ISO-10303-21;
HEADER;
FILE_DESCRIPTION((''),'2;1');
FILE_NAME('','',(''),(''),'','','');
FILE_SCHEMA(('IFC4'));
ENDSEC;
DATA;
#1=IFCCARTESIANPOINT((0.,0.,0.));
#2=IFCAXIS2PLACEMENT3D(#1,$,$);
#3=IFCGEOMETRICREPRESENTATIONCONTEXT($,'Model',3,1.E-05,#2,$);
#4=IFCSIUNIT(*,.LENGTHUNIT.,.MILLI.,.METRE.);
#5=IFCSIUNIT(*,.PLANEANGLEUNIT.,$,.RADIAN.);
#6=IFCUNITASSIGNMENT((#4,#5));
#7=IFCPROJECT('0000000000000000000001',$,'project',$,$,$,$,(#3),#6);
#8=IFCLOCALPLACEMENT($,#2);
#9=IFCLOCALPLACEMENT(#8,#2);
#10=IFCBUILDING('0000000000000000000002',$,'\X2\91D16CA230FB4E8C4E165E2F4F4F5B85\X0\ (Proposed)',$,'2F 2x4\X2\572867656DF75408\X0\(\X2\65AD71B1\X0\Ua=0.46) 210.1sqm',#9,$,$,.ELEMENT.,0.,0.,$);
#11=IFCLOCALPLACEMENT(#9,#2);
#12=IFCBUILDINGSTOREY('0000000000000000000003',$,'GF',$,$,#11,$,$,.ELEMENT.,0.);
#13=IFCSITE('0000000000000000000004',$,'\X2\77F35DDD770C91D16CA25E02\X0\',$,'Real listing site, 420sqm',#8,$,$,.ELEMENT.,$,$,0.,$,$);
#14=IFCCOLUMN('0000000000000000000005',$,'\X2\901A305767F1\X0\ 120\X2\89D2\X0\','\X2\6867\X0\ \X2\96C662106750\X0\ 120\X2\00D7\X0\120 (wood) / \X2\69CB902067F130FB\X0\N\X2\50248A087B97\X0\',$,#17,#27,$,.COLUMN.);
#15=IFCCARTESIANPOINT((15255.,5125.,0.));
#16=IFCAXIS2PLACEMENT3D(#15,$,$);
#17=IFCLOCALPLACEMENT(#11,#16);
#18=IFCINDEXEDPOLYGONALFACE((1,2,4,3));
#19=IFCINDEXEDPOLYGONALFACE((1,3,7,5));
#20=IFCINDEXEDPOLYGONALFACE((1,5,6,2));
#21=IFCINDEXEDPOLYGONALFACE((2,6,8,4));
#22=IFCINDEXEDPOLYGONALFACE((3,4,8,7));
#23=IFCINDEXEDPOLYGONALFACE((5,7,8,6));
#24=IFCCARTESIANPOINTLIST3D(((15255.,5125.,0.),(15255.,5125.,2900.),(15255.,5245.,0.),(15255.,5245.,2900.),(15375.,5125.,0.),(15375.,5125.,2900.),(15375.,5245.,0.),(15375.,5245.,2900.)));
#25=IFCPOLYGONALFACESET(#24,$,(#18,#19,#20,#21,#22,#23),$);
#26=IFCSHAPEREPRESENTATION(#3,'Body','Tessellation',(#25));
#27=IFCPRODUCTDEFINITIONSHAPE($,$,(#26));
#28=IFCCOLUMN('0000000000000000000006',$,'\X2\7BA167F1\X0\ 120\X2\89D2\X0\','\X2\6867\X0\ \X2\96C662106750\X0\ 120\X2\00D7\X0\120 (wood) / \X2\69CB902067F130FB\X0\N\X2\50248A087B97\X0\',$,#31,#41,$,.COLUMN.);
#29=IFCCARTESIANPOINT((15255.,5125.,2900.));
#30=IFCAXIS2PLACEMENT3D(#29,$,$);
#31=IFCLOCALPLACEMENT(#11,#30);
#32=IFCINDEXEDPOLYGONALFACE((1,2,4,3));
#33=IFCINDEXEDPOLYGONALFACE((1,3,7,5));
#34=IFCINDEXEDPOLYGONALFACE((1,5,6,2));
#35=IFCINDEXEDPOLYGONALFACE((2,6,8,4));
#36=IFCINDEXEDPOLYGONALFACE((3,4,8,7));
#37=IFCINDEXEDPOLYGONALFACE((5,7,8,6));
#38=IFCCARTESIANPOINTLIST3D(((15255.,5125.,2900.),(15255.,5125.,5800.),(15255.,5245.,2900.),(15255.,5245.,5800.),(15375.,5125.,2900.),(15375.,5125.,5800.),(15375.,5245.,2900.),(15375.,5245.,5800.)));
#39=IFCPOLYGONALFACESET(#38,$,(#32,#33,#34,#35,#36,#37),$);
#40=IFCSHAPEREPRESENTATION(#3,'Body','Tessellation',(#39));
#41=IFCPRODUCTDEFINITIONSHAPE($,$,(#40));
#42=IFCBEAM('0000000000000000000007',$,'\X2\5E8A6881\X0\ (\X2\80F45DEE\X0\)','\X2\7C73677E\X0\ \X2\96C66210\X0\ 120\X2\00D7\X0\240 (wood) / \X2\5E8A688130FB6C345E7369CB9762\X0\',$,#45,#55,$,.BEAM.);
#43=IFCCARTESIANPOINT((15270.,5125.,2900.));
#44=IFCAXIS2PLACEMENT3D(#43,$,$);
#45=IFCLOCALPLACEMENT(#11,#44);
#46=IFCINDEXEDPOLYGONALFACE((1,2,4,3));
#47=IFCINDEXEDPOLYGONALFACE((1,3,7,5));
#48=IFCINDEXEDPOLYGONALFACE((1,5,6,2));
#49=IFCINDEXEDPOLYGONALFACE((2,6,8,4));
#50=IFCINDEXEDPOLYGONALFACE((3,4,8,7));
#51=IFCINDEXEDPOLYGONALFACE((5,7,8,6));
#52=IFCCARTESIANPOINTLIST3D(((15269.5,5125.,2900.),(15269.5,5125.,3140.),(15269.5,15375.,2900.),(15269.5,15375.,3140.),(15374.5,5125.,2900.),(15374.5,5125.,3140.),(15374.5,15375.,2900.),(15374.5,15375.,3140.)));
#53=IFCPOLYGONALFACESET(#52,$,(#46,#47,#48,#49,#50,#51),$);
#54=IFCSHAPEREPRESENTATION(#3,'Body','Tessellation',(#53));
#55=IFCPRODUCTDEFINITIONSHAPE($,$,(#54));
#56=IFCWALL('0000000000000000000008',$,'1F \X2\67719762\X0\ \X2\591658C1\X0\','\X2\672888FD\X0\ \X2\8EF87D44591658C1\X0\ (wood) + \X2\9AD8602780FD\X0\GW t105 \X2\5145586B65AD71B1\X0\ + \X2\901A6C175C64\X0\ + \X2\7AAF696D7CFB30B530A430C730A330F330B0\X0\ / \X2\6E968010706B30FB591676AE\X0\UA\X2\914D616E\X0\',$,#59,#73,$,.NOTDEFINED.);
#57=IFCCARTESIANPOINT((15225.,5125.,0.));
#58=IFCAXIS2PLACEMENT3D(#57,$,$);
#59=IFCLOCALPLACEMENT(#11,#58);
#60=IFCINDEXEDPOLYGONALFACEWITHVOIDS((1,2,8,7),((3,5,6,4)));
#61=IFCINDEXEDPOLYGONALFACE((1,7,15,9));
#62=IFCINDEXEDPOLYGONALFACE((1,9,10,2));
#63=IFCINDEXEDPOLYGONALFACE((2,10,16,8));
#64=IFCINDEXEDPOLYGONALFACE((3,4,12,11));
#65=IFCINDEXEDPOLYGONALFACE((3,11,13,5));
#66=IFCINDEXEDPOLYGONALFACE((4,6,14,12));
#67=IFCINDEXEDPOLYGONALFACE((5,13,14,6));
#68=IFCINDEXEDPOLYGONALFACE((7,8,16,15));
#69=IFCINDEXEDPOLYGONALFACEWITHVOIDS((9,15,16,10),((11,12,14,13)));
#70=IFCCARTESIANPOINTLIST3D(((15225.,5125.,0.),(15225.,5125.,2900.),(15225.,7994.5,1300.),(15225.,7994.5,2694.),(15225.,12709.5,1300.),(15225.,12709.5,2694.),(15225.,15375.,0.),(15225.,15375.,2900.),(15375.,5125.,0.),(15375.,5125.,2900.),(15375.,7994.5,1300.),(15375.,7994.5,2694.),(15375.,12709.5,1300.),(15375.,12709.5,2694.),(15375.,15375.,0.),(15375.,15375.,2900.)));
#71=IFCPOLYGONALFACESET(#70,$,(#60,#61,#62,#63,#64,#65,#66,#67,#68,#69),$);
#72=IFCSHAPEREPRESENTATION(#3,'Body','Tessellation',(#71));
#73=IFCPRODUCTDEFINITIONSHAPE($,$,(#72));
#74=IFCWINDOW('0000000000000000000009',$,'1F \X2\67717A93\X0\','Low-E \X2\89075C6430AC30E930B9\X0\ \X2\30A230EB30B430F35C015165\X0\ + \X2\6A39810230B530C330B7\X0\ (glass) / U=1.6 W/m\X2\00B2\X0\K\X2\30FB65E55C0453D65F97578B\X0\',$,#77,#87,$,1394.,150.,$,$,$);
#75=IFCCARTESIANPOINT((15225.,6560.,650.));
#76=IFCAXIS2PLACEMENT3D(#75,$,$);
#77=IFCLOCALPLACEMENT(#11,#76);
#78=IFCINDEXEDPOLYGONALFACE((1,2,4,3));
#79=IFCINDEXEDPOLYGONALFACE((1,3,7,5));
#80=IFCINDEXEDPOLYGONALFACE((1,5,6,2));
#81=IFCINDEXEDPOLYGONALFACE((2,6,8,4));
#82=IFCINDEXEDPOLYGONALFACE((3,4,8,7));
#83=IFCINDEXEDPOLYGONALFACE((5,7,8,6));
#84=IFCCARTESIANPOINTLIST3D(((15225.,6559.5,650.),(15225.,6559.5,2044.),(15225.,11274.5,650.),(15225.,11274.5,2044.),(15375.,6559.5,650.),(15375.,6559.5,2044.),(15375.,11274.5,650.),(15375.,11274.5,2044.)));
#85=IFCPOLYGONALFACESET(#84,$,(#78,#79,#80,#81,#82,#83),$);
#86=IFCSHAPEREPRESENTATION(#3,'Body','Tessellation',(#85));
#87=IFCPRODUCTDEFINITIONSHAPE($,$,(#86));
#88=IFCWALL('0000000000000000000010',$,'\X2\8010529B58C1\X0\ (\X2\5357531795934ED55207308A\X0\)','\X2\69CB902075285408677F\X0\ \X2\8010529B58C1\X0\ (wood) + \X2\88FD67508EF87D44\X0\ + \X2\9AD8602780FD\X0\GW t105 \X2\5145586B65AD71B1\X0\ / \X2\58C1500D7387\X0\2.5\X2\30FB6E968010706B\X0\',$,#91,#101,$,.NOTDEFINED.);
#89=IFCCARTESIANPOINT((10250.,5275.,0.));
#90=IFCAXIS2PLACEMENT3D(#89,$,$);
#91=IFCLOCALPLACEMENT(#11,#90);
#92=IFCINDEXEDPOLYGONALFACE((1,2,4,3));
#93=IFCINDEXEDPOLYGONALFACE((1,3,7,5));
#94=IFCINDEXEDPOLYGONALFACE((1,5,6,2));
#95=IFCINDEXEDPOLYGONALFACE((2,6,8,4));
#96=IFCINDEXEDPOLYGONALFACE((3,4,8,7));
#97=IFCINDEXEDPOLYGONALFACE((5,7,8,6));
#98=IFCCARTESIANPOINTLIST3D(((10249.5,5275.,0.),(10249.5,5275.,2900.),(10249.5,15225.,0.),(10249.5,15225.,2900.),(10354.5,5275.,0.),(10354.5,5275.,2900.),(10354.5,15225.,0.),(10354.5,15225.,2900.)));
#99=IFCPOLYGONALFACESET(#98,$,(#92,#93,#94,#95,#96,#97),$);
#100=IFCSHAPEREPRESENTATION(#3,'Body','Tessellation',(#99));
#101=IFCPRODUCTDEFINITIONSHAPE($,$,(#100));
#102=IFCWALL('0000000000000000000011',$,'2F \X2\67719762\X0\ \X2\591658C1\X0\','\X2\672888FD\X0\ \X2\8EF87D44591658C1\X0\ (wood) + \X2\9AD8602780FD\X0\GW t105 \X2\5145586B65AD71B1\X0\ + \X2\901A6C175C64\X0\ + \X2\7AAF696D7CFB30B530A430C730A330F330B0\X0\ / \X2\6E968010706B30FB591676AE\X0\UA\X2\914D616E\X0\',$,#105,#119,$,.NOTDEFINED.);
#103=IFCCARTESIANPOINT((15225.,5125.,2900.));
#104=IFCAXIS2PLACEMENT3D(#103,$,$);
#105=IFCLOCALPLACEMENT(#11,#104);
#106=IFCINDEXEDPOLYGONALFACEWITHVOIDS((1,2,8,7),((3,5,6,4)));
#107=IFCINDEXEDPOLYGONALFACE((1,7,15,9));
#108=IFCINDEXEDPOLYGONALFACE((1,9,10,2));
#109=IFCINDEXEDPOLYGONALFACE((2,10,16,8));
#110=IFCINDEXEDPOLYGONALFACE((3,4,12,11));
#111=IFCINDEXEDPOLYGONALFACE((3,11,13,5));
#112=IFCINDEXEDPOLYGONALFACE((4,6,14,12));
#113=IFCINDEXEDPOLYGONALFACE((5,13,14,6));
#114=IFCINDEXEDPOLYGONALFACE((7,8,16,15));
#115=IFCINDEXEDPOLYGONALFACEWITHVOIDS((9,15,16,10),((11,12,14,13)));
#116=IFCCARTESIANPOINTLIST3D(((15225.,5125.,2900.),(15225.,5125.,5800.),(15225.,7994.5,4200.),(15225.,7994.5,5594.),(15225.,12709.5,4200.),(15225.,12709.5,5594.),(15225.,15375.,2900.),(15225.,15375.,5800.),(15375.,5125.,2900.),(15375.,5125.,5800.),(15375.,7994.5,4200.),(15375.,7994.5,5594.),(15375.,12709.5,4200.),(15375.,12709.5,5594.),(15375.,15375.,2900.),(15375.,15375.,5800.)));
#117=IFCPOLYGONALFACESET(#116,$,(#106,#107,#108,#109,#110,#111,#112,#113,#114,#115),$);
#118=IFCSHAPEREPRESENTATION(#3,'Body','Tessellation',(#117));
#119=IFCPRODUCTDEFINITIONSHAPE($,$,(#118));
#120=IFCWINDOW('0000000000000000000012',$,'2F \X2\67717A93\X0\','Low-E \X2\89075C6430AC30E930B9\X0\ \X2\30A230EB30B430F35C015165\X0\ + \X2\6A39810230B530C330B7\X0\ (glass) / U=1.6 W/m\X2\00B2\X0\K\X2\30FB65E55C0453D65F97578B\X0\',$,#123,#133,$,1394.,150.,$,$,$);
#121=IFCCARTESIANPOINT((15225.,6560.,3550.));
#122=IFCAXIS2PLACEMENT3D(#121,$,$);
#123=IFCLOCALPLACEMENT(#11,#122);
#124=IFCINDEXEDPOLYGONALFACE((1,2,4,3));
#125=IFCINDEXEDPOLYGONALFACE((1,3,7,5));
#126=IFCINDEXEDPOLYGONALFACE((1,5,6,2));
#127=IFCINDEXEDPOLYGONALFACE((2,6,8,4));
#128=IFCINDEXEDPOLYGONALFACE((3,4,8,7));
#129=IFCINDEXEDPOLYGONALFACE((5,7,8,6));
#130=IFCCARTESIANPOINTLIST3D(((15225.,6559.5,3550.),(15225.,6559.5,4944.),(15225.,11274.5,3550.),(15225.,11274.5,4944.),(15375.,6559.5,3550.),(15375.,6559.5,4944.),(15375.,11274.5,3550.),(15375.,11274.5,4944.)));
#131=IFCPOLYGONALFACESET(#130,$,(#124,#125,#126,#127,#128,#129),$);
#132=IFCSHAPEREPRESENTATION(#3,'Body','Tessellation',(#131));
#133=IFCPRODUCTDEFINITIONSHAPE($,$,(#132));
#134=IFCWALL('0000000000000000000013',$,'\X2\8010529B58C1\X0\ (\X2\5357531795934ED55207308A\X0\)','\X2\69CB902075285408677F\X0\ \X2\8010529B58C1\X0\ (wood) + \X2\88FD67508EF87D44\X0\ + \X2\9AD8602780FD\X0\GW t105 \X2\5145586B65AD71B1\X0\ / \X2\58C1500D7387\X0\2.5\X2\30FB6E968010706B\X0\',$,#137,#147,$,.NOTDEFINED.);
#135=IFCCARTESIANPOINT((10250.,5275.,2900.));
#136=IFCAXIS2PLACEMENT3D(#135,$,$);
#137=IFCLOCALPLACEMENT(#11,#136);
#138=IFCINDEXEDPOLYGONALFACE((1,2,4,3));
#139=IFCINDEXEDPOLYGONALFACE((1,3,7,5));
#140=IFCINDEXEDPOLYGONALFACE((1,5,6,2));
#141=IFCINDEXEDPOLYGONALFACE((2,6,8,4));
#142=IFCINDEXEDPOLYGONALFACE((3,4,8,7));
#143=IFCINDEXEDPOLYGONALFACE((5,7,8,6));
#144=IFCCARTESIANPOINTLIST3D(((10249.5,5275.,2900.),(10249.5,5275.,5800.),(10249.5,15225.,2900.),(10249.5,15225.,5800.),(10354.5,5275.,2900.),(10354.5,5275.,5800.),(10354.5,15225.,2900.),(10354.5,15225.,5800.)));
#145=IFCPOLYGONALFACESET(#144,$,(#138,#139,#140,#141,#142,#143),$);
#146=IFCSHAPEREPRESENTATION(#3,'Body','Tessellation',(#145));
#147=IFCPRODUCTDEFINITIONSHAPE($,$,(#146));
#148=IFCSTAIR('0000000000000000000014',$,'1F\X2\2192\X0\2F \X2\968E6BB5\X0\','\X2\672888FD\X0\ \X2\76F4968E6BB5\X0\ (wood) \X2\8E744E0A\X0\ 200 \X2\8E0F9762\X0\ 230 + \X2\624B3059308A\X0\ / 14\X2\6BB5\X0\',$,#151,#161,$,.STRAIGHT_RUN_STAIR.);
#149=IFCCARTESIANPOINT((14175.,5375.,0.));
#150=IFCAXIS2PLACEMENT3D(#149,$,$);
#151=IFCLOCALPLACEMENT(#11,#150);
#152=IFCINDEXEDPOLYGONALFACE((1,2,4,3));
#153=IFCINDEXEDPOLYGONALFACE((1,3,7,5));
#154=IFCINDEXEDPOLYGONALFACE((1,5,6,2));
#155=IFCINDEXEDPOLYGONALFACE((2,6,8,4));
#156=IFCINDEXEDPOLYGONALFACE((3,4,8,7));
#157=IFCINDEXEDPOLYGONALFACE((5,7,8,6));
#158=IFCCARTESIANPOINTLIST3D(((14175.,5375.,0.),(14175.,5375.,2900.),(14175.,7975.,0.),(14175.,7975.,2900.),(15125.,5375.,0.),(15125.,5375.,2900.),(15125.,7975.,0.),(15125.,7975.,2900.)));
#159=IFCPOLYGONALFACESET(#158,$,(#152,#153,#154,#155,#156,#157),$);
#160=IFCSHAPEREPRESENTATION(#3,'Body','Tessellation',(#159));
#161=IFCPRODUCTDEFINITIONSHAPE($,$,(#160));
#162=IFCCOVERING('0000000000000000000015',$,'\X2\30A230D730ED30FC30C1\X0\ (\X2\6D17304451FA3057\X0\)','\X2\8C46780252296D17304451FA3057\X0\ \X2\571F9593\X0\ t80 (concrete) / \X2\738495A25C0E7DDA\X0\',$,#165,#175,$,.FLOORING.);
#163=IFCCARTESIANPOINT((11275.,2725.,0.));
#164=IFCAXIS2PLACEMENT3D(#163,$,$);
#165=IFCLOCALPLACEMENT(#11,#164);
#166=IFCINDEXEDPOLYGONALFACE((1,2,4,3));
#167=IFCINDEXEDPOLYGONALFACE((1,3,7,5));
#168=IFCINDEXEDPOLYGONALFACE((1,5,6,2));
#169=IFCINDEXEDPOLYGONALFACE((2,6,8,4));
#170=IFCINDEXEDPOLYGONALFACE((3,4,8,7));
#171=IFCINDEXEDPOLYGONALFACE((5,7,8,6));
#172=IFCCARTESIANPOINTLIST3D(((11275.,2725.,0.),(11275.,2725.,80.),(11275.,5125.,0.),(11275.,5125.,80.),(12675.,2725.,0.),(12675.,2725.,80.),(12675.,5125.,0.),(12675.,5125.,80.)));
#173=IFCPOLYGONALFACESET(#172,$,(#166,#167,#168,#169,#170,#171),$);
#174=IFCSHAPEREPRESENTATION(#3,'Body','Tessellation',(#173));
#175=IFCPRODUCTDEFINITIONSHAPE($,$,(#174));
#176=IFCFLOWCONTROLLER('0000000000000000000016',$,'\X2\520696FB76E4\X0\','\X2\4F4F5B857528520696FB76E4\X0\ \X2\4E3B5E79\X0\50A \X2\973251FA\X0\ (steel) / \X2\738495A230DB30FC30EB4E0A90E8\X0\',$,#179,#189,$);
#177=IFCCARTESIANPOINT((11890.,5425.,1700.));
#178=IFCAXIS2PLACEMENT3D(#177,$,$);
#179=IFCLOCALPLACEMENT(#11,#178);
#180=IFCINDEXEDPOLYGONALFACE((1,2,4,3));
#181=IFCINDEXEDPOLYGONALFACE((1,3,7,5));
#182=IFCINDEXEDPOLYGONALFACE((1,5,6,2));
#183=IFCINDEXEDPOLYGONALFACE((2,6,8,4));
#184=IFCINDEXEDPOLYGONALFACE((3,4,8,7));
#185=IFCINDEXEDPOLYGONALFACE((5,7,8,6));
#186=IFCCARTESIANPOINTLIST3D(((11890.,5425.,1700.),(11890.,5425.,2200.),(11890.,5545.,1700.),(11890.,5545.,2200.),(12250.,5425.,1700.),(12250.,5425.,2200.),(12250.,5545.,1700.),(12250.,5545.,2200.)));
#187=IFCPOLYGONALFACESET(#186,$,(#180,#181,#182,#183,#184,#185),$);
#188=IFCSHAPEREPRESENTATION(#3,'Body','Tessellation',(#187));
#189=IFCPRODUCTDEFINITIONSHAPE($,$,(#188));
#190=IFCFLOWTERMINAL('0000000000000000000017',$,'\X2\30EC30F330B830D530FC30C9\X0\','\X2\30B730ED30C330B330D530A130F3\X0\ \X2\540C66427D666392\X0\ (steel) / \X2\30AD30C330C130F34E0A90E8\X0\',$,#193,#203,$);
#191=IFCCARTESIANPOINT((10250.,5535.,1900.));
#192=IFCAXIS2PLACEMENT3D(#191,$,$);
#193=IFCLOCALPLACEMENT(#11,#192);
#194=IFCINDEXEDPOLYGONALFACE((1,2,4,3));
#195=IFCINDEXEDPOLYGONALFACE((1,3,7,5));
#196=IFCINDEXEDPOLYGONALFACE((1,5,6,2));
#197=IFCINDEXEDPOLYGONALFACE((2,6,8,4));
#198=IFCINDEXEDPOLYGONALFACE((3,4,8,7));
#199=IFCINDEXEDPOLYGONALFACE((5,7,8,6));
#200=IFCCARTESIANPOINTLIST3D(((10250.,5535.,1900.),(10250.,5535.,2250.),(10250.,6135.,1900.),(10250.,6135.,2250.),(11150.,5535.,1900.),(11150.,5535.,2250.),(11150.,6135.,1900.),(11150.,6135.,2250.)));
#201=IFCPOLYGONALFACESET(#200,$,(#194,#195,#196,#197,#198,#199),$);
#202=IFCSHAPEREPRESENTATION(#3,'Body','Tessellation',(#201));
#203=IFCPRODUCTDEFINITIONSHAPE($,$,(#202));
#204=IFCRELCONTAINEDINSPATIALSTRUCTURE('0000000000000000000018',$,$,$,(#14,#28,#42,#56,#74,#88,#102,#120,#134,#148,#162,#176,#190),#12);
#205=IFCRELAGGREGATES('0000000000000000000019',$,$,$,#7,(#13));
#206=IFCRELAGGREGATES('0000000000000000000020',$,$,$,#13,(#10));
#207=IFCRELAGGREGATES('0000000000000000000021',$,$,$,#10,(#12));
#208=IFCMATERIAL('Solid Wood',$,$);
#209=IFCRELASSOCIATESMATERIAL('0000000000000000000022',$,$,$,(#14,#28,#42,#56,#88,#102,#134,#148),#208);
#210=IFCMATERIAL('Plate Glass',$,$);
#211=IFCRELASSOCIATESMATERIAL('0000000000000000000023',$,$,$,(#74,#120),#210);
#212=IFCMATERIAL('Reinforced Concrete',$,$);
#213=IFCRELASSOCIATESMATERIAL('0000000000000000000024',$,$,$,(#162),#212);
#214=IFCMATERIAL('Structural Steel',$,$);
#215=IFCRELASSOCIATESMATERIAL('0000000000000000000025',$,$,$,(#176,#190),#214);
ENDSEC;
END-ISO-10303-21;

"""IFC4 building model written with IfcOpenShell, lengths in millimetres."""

from ifc_helpers import new_model, si_unit, frame, frame_2d, origin, place, context, project, spatial, rectangle, extrude, material, element, fill, save


model = new_model("IFC4")

# Units and contexts
model_context = context("Model", 3, precision=1e-05, world=origin())
ifc_project = project(units=[si_unit("LENGTHUNIT", "METRE", prefix="MILLI"), si_unit("PLANEANGLEUNIT", "RADIAN")], contexts=[model_context])

# Site, building, storey
site_placement = place(None, origin())
site = spatial("IfcSite", under=ifc_project, at=site_placement, Name="石川県金沢市", ObjectType="Real listing site, 420sqm", CompositionType="ELEMENT", RefElevation=0.0)
building_placement = place(site_placement, origin())
building = spatial("IfcBuilding", under=site, at=building_placement, Name="金沢・二世帯住宅 (Proposed)", ObjectType="2F 2x4在来混合(断熱Ua=0.46) 210.1sqm", CompositionType="ELEMENT", ElevationOfRefHeight=0.0, ElevationOfTerrain=0.0)
storey_placement = place(building_placement, origin())
storey = spatial("IfcBuildingStorey", under=building, at=storey_placement, Name="GF", CompositionType="ELEMENT", Elevation=0.0)

# Columns
ifc_material_1 = material(Name="Solid Wood")
column_1_placement = place(storey_placement, frame((15255.0, 5125.0, 0.0)))
element("IfcColumn", 1, at=column_1_placement, inside=storey, material=ifc_material_1, Name="通し柱 120角", Description="桧 集成材 120×120 (wood) / 構造柱・N値計算", PredefinedType="COLUMN", context=model_context, shape_type="SweptSolid", body=[
    extrude(rectangle(XDim=120.0, YDim=120.0, at=frame_2d((60.0, 60.0))), frame((15255.0, 5125.0, 0.0)), (0.0, 0.0, 1.0), 2900.0),
])
column_2_placement = place(storey_placement, frame((15255.0, 5125.0, 2900.0)))
element("IfcColumn", 2, at=column_2_placement, inside=storey, material=ifc_material_1, Name="管柱 120角", Description="桧 集成材 120×120 (wood) / 構造柱・N値計算", PredefinedType="COLUMN", context=model_context, shape_type="SweptSolid", body=[
    extrude(rectangle(XDim=120.0, YDim=120.0, at=frame_2d((60.0, 60.0))), frame((15255.0, 5125.0, 2900.0)), (0.0, 0.0, 1.0), 2900.0),
])

# Beam
beam_1_placement = place(storey_placement, frame((15270.0, 5125.0, 2900.0)))
element("IfcBeam", 3, at=beam_1_placement, inside=storey, material=ifc_material_1, Name="床梁 (胴差)", Description="米松 集成 120×240 (wood) / 床梁・水平構面", PredefinedType="BEAM", context=model_context, shape_type="SweptSolid", body=[
    extrude(rectangle(XDim=105.0, YDim=10250.0, at=frame_2d((52.0, 5125.0))), frame((15270.0, 5125.0, 2900.0)), (0.0, 0.0, 1.0), 240.0),
])

# Wall, opening, window
wall_1_placement = place(storey_placement, frame((15225.0, 5125.0, 0.0)))
wall_1 = element("IfcWall", 4, at=wall_1_placement, inside=storey, material=ifc_material_1, Name="1F 東面 外壁", Description="木製 軸組外壁 (wood) + 高性能GW t105 充填断熱 + 通気層 + 窯業系サイディング / 準耐火・外皮UA配慮", PredefinedType="NOTDEFINED", context=model_context, shape_type="SweptSolid", body=[
    extrude(rectangle(XDim=150.0, YDim=10250.0, at=frame_2d((75.0, 5125.0))), frame((15225.0, 5125.0, 0.0)), (0.0, 0.0, 1.0), 2900.0),
])
opening_1_placement = place(storey_placement, frame((15225.0, 6560.0, 650.0)))
opening_1 = element("IfcOpeningElement", 5, at=opening_1_placement, cuts=wall_1, PredefinedType="NOTDEFINED", context=model_context, shape_type="SweptSolid", body=[
    extrude(rectangle(XDim=150.0, YDim=4715.0, at=frame_2d((75.0, 2357.0))), frame((15225.0, 6560.0, 650.0)), (0.0, 0.0, 1.0), 1394.0),
])
ifc_material_2 = material(Name="Plate Glass")
window_1_placement = place(storey_placement, frame((15225.0, 6560.0, 650.0)))
window_1 = element("IfcWindow", 6, at=window_1_placement, inside=storey, material=ifc_material_2, Name="1F 東窓", Description="Low-E 複層ガラス アルゴン封入 + 樹脂サッシ (glass) / U=1.6 W/m²K・日射取得型", OverallHeight=1394.0, OverallWidth=150.0, context=model_context, shape_type="SweptSolid", body=[
    extrude(rectangle(XDim=150.0, YDim=4715.0, at=frame_2d((75.0, 2357.0))), frame((15225.0, 6560.0, 650.0)), (0.0, 0.0, 1.0), 1394.0),
])
fill(opening_1, window_1)

# Wall
wall_2_placement = place(storey_placement, frame((10250.0, 5275.0, 0.0)))
element("IfcWall", 7, at=wall_2_placement, inside=storey, material=ifc_material_1, Name="耐力壁 (南北間仕切り)", Description="構造用合板 耐力壁 (wood) + 製材軸組 + 高性能GW t105 充填断熱 / 壁倍率2.5・準耐火", PredefinedType="NOTDEFINED", context=model_context, shape_type="SweptSolid", body=[
    extrude(rectangle(XDim=105.0, YDim=9950.0, at=frame_2d((52.0, 4975.0))), frame((10250.0, 5275.0, 0.0)), (0.0, 0.0, 1.0), 2900.0),
])

# Wall, opening, window
wall_3_placement = place(storey_placement, frame((15225.0, 5125.0, 2900.0)))
wall_3 = element("IfcWall", 8, at=wall_3_placement, inside=storey, material=ifc_material_1, Name="2F 東面 外壁", Description="木製 軸組外壁 (wood) + 高性能GW t105 充填断熱 + 通気層 + 窯業系サイディング / 準耐火・外皮UA配慮", PredefinedType="NOTDEFINED", context=model_context, shape_type="SweptSolid", body=[
    extrude(rectangle(XDim=150.0, YDim=10250.0, at=frame_2d((75.0, 5125.0))), frame((15225.0, 5125.0, 2900.0)), (0.0, 0.0, 1.0), 2900.0),
])
opening_2_placement = place(storey_placement, frame((15225.0, 6560.0, 3550.0)))
opening_2 = element("IfcOpeningElement", 9, at=opening_2_placement, cuts=wall_3, PredefinedType="NOTDEFINED", context=model_context, shape_type="SweptSolid", body=[
    extrude(rectangle(XDim=150.0, YDim=4715.0, at=frame_2d((75.0, 2357.0))), frame((15225.0, 6560.0, 3550.0)), (0.0, 0.0, 1.0), 1394.0),
])
window_2_placement = place(storey_placement, frame((15225.0, 6560.0, 3550.0)))
window_2 = element("IfcWindow", 10, at=window_2_placement, inside=storey, material=ifc_material_2, Name="2F 東窓", Description="Low-E 複層ガラス アルゴン封入 + 樹脂サッシ (glass) / U=1.6 W/m²K・日射取得型", OverallHeight=1394.0, OverallWidth=150.0, context=model_context, shape_type="SweptSolid", body=[
    extrude(rectangle(XDim=150.0, YDim=4715.0, at=frame_2d((75.0, 2357.0))), frame((15225.0, 6560.0, 3550.0)), (0.0, 0.0, 1.0), 1394.0),
])
fill(opening_2, window_2)

# Wall
wall_4_placement = place(storey_placement, frame((10250.0, 5275.0, 2900.0)))
element("IfcWall", 11, at=wall_4_placement, inside=storey, material=ifc_material_1, Name="耐力壁 (南北間仕切り)", Description="構造用合板 耐力壁 (wood) + 製材軸組 + 高性能GW t105 充填断熱 / 壁倍率2.5・準耐火", PredefinedType="NOTDEFINED", context=model_context, shape_type="SweptSolid", body=[
    extrude(rectangle(XDim=105.0, YDim=9950.0, at=frame_2d((52.0, 4975.0))), frame((10250.0, 5275.0, 2900.0)), (0.0, 0.0, 1.0), 2900.0),
])

# Stair
stair_placement = place(storey_placement, frame((14175.0, 5375.0, 0.0)))
element("IfcStair", 12, at=stair_placement, inside=storey, material=ifc_material_1, Name="1F→2F 階段", Description="木製 直階段 (wood) 蹴上 200 踏面 230 + 手すり / 14段", PredefinedType="STRAIGHT_RUN_STAIR", context=model_context, shape_type="SweptSolid", body=[
    extrude(rectangle(XDim=950.0, YDim=2600.0, at=frame_2d((475.0, 1300.0))), frame((14175.0, 5375.0, 0.0)), (0.0, 0.0, 1.0), 2900.0),
])

# Covering
ifc_material_3 = material(Name="Reinforced Concrete")
covering_placement = place(storey_placement, frame((11275.0, 2725.0, 0.0)))
element("IfcCovering", 13, at=covering_placement, inside=storey, material=ifc_material_3, Name="アプローチ (洗い出し)", Description="豆砂利洗い出し 土間 t80 (concrete) / 玄関導線", PredefinedType="FLOORING", context=model_context, shape_type="SweptSolid", body=[
    extrude(rectangle(XDim=1400.0, YDim=2400.0, at=frame_2d((700.0, 1200.0))), frame((11275.0, 2725.0, 0.0)), (0.0, 0.0, 1.0), 80.0),
])

# Flow controller
ifc_material_4 = material(Name="Structural Steel")
flow_controller_placement = place(storey_placement, frame((11890.0, 5425.0, 1700.0)))
element("IfcFlowController", 14, at=flow_controller_placement, inside=storey, material=ifc_material_4, Name="分電盤", Description="住宅用分電盤 主幹50A 露出 (steel) / 玄関ホール上部", context=model_context, shape_type="SweptSolid", body=[
    extrude(rectangle(XDim=360.0, YDim=120.0, at=frame_2d((180.0, 60.0))), frame((11890.0, 5425.0, 1700.0)), (0.0, 0.0, 1.0), 500.0),
])

# Flow terminal
flow_terminal_1_placement = place(storey_placement, frame((10250.0, 5535.0, 1900.0)))
element("IfcFlowTerminal", 15, at=flow_terminal_1_placement, inside=storey, material=ifc_material_4, Name="レンジフード", Description="シロッコファン 同時給排 (steel) / キッチン上部", context=model_context, shape_type="SweptSolid", body=[
    extrude(rectangle(XDim=900.0, YDim=600.0, at=frame_2d((450.0, 300.0))), frame((10250.0, 5535.0, 1900.0)), (0.0, 0.0, 1.0), 350.0),
])

save(model, "model.ifc")
